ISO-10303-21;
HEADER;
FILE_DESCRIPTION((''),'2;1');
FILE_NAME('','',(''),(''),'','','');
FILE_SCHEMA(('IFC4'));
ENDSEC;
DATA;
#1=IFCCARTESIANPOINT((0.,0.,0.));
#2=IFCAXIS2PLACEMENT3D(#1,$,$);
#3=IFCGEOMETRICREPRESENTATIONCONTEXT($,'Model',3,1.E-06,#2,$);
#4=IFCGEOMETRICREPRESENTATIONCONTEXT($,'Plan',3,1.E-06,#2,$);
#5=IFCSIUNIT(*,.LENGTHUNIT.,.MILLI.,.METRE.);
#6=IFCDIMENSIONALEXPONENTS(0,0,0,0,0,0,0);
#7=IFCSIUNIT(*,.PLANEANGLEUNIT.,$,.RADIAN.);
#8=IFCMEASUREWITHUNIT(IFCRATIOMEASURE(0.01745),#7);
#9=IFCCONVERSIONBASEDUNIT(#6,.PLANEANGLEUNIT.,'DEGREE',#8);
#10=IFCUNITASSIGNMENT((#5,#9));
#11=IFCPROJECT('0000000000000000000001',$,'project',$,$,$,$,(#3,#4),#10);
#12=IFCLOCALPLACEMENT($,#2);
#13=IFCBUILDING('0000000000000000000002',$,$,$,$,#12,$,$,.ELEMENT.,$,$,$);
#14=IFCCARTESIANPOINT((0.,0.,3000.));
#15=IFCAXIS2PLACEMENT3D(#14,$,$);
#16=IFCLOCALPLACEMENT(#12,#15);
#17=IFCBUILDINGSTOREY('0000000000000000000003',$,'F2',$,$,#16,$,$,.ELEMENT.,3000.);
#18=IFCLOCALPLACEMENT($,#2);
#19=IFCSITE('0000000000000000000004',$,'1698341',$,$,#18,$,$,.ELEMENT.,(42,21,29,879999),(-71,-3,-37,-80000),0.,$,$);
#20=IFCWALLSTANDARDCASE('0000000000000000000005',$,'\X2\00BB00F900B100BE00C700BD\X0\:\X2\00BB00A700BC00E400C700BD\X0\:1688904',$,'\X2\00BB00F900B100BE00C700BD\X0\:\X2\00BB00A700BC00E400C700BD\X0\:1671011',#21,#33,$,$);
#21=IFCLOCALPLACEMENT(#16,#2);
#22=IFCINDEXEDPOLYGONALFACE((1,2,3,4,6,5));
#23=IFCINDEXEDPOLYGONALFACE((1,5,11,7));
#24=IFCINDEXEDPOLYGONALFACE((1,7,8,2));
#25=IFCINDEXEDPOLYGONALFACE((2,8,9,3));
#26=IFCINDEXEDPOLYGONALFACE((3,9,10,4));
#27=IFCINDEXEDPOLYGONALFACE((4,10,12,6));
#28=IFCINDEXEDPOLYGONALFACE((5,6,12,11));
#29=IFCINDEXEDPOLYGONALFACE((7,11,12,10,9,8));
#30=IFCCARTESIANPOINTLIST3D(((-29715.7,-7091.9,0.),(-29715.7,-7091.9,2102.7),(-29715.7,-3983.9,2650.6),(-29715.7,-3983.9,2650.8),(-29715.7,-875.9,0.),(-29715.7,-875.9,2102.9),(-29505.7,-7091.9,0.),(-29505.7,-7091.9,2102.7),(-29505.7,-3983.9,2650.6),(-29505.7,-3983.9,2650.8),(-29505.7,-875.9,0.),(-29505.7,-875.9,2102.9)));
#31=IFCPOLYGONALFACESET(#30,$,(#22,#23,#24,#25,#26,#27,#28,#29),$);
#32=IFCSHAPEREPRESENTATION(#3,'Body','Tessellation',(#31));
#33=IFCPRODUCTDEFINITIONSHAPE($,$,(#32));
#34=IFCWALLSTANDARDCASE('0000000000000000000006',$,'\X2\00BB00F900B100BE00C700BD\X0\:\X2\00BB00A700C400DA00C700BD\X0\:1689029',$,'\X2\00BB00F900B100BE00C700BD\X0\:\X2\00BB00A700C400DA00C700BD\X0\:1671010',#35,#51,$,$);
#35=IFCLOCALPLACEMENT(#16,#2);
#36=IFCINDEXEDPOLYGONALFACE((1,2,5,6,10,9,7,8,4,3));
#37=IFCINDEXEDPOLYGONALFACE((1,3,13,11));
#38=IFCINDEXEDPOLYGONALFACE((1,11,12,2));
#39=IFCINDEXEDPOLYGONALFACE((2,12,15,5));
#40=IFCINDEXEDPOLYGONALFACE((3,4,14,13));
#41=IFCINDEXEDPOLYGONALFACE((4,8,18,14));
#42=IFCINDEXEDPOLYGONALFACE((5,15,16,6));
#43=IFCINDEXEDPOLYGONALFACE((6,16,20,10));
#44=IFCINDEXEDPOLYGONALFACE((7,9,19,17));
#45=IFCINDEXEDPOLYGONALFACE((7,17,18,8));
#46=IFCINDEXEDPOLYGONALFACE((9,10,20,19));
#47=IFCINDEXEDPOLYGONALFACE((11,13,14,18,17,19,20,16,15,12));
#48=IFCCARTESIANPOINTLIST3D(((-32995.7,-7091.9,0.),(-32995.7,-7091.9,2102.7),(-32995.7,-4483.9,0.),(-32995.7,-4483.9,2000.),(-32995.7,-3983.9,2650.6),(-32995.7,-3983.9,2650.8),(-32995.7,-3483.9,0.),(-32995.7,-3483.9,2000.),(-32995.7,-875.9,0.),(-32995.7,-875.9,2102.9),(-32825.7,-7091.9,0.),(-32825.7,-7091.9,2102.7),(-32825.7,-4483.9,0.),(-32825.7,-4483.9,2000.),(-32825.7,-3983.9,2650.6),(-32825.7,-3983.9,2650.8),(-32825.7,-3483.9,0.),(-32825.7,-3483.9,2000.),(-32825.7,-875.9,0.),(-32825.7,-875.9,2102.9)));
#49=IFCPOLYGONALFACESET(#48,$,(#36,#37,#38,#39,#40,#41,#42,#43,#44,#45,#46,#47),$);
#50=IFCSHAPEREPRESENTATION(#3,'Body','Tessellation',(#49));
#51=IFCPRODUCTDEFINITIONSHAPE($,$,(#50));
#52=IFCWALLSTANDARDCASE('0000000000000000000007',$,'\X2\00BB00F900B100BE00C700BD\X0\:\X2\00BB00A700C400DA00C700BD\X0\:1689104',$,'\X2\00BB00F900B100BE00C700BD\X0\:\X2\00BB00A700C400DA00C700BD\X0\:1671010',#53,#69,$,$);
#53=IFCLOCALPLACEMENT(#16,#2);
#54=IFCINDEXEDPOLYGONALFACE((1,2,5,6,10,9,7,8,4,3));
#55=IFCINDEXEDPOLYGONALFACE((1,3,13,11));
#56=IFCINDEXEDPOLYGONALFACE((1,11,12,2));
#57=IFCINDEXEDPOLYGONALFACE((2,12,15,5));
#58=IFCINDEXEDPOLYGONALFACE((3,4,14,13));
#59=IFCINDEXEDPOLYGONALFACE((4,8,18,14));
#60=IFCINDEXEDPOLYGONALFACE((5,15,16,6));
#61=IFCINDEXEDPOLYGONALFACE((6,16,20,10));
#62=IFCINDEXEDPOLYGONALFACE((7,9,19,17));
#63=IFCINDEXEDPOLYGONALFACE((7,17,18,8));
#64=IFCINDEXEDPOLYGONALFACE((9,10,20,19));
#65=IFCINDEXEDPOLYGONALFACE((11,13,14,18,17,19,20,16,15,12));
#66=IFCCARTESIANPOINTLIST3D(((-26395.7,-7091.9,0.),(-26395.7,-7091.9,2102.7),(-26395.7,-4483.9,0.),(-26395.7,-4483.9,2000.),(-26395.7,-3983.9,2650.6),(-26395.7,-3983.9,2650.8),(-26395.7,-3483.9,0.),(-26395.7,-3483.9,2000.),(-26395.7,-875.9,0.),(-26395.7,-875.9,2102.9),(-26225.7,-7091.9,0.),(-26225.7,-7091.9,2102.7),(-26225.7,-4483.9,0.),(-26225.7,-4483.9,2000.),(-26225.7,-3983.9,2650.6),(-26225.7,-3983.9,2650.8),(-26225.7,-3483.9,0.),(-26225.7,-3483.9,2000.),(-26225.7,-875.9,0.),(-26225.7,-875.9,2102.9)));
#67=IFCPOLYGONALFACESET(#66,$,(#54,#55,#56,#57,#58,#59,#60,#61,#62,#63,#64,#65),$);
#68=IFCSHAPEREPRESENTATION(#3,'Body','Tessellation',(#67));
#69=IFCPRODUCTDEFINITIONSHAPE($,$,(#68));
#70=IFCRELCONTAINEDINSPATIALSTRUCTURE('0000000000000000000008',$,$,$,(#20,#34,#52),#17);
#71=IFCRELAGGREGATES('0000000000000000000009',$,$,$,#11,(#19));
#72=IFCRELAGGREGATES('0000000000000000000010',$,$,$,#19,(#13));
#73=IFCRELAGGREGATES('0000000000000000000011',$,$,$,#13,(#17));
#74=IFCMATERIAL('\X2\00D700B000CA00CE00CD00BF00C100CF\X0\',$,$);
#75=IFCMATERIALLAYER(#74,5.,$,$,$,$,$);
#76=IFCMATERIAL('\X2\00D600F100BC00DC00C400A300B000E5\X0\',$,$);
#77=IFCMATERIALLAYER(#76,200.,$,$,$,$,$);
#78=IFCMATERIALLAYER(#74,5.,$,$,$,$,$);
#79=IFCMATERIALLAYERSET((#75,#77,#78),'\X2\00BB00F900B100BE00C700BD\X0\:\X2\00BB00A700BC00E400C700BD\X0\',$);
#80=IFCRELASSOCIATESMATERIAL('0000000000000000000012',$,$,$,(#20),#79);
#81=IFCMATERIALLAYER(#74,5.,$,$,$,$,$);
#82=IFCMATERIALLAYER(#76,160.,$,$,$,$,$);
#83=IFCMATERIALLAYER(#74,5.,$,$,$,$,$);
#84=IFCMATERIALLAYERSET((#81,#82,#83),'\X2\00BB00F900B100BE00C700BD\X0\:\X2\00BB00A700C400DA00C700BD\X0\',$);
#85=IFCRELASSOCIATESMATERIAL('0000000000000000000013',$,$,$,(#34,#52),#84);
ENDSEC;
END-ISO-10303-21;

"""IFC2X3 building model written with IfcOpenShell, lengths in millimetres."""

from ifc_helpers import new_model, entity, si_unit, converted_unit, frame, frame_2d, origin, place, context, project, spatial, polyline, rectangle, extrude, clip, bounded_halfspace, material, layer, layer_set, layer_usage, element, save


model = new_model("IFC2X3")

# Units and contexts
model_context = context("Model", 3, precision=1e-06, world=origin())
plan_context = context("Plan", 3, precision=1e-06, world=origin())
ifc_project = project(units=[si_unit("LENGTHUNIT", "METRE", prefix="MILLI"), converted_unit("PLANEANGLEUNIT", "DEGREE", entity("IfcRatioMeasure", 0.01745), si_unit("PLANEANGLEUNIT", "RADIAN"), dimensions=[0, 0, 0, 0, 0, 0, 0])], contexts=[model_context, plan_context])

# Site, building, storey
site_placement = place(None, origin())
site = spatial("IfcSite", under=ifc_project, at=site_placement, Name="1698341", CompositionType="ELEMENT", RefLatitude=(42, 21, 29, 879999), RefLongitude=(-71, -3, -37, -80000), RefElevation=0.0)
building_placement = place(None, origin())
building = spatial("IfcBuilding", under=site, at=building_placement, CompositionType="ELEMENT")
storey_placement = place(building_placement, frame((0.0, 0.0, 3000.0)))
storey = spatial("IfcBuildingStorey", under=building, at=storey_placement, Name="F2", CompositionType="ELEMENT", Elevation=3000.0)

# Shared definitions
ifc_material_1 = material(Name="Öñ¼ÜÄ£°å")

# Shared definitions
ifc_material_2 = material(Name="×°ÊÎÍ¿ÁÏ")

# Wall
ifc_layer_1 = layer(ifc_material_2, 5.0)
ifc_layer_2 = layer(ifc_material_1, 200.0)
ifc_layer_3 = layer(ifc_material_2, 5.0)
ifc_layer_set_1 = layer_set([ifc_layer_1, ifc_layer_2, ifc_layer_3], Name="»ù±¾Ç½:»§¼äÇ½")
ifc_layer_usage_1 = layer_usage(ifc_layer_set_1, "AXIS2", "NEGATIVE", 105.0)
wall_1_placement = place(storey_placement, frame((-29610.7, -7091.9, 0.0), z_axis=(0.0, 0.0, 1.0), x_axis=(0.0, 1.0, 0.0)))
element("IfcWallStandardCase", 1, at=wall_1_placement, inside=storey, material=ifc_layer_usage_1, Name="»ù±¾Ç½:»§¼äÇ½:1688904", ObjectType="»ù±¾Ç½:»§¼äÇ½:1671011", context=model_context, shape_type="Clipping", body=[
    clip(clip(extrude(rectangle(XDim=6216.0, YDim=210.0, at=frame_2d((3108.0, 0.0), x_axis=(-1.0, 0.0))), origin(), (0.0, 0.0, 1.0), 3200.0), bounded_halfspace(frame((0.0, -105.0, 2102.7), z_axis=(0.1736, 0.0, -0.9848), x_axis=(0.0, 1.0, 0.0)), True, frame((0.0, -105.0, 2102.7)), polyline([(0.0, 0.0), (3108.0, 0.0), (3108.0, 210.0), (0.0, 210.0), (0.0, 0.0)]))), bounded_halfspace(frame((3108.0, -105.0, 2650.8), z_axis=(-0.1736, 0.0, -0.9848), x_axis=(0.0, 1.0, 0.0)), True, frame((3108.0, -105.0, 2650.8)), polyline([(0.0, 0.0), (3108.0, 0.0), (3108.0, 210.0), (0.0, 210.0), (0.0, 0.0)]))),
])

# Walls, openings
ifc_layer_4 = layer(ifc_material_2, 5.0)
ifc_layer_5 = layer(ifc_material_1, 160.0)
ifc_layer_6 = layer(ifc_material_2, 5.0)
ifc_layer_set_2 = layer_set([ifc_layer_4, ifc_layer_5, ifc_layer_6], Name="»ù±¾Ç½:»§ÄÚÇ½")
ifc_layer_usage_2 = layer_usage(ifc_layer_set_2, "AXIS2", "NEGATIVE", 85.0)
wall_2_placement = place(storey_placement, frame((-32910.7, -7091.9, 0.0), z_axis=(0.0, 0.0, 1.0), x_axis=(0.0, 1.0, 0.0)))
wall_2 = element("IfcWallStandardCase", 2, at=wall_2_placement, inside=storey, material=ifc_layer_usage_2, Name="»ù±¾Ç½:»§ÄÚÇ½:1689029", ObjectType="»ù±¾Ç½:»§ÄÚÇ½:1671010", context=model_context, shape_type="Clipping", body=[
    clip(clip(extrude(rectangle(XDim=6216.0, YDim=170.0, at=frame_2d((3108.0, 0.0), x_axis=(-1.0, 0.0))), origin(), (0.0, 0.0, 1.0), 3200.0), bounded_halfspace(frame((0.0, -85.0, 2102.7), z_axis=(0.1736, 0.0, -0.9848), x_axis=(0.0, 1.0, 0.0)), True, frame((0.0, -85.0, 2102.7)), polyline([(0.0, 0.0), (3108.0, 0.0), (3108.0, 170.0), (0.0, 170.0), (0.0, 0.0)]))), bounded_halfspace(frame((3108.0, -85.0, 2650.8), z_axis=(-0.1736, 0.0, -0.9848), x_axis=(0.0, 1.0, 0.0)), True, frame((3108.0, -85.0, 2650.8)), polyline([(0.0, 0.0), (3108.0, 0.0), (3108.0, 170.0), (0.0, 170.0), (0.0, 0.0)]))),
])
opening_1_placement = place(wall_2_placement, frame((2608.0, -85.0, 0.0)))
element("IfcOpeningElement", 3, at=opening_1_placement, cuts=wall_2, ObjectType="Opening", context=model_context, shape_type="SweptSolid", body=[
    extrude(rectangle(XDim=1000.0, YDim=2000.0, at=frame_2d((1000.0, 500.0), x_axis=(0.0, -1.0))), frame((0.0, 0.0, 0.0), z_axis=(0.0, 1.0, 0.0), x_axis=(0.0, 0.0, 1.0)), (0.0, 0.0, 1.0), 170.0),
])
ifc_layer_usage_3 = layer_usage(ifc_layer_set_2, "AXIS2", "POSITIVE", -85.0)
wall_3_placement = place(storey_placement, frame((-26310.7, -7091.9, 0.0), z_axis=(0.0, 0.0, 1.0), x_axis=(0.0, 1.0, 0.0)))
wall_3 = element("IfcWallStandardCase", 4, at=wall_3_placement, inside=storey, material=ifc_layer_usage_3, Name="»ù±¾Ç½:»§ÄÚÇ½:1689104", ObjectType="»ù±¾Ç½:»§ÄÚÇ½:1671010", context=model_context, shape_type="Clipping", body=[
    clip(clip(extrude(rectangle(XDim=6216.0, YDim=170.0, at=frame_2d((3108.0, 0.0), x_axis=(-1.0, 0.0))), origin(), (0.0, 0.0, 1.0), 3200.0), bounded_halfspace(frame((0.0, -85.0, 2102.7), z_axis=(0.1736, 0.0, -0.9848), x_axis=(0.0, 1.0, 0.0)), True, frame((0.0, -85.0, 2102.7)), polyline([(0.0, 0.0), (3108.0, 0.0), (3108.0, 170.0), (0.0, 170.0), (0.0, 0.0)]))), bounded_halfspace(frame((3108.0, -85.0, 2650.8), z_axis=(-0.1736, 0.0, -0.9848), x_axis=(0.0, 1.0, 0.0)), True, frame((3108.0, -85.0, 2650.8)), polyline([(0.0, 0.0), (3108.0, 0.0), (3108.0, 170.0), (0.0, 170.0), (0.0, 0.0)]))),
])
opening_2_placement = place(wall_3_placement, frame((3608.0, 85.0, 0.0)))
element("IfcOpeningElement", 5, at=opening_2_placement, cuts=wall_3, ObjectType="Opening", context=model_context, shape_type="SweptSolid", body=[
    extrude(rectangle(XDim=1000.0, YDim=2000.0, at=frame_2d((1000.0, 500.0), x_axis=(0.0, 1.0))), frame((0.0, 0.0, 0.0), z_axis=(0.0, -1.0, 0.0), x_axis=(0.0, 0.0, 1.0)), (0.0, 0.0, 1.0), 170.0),
])

save(model, "model.ifc")
